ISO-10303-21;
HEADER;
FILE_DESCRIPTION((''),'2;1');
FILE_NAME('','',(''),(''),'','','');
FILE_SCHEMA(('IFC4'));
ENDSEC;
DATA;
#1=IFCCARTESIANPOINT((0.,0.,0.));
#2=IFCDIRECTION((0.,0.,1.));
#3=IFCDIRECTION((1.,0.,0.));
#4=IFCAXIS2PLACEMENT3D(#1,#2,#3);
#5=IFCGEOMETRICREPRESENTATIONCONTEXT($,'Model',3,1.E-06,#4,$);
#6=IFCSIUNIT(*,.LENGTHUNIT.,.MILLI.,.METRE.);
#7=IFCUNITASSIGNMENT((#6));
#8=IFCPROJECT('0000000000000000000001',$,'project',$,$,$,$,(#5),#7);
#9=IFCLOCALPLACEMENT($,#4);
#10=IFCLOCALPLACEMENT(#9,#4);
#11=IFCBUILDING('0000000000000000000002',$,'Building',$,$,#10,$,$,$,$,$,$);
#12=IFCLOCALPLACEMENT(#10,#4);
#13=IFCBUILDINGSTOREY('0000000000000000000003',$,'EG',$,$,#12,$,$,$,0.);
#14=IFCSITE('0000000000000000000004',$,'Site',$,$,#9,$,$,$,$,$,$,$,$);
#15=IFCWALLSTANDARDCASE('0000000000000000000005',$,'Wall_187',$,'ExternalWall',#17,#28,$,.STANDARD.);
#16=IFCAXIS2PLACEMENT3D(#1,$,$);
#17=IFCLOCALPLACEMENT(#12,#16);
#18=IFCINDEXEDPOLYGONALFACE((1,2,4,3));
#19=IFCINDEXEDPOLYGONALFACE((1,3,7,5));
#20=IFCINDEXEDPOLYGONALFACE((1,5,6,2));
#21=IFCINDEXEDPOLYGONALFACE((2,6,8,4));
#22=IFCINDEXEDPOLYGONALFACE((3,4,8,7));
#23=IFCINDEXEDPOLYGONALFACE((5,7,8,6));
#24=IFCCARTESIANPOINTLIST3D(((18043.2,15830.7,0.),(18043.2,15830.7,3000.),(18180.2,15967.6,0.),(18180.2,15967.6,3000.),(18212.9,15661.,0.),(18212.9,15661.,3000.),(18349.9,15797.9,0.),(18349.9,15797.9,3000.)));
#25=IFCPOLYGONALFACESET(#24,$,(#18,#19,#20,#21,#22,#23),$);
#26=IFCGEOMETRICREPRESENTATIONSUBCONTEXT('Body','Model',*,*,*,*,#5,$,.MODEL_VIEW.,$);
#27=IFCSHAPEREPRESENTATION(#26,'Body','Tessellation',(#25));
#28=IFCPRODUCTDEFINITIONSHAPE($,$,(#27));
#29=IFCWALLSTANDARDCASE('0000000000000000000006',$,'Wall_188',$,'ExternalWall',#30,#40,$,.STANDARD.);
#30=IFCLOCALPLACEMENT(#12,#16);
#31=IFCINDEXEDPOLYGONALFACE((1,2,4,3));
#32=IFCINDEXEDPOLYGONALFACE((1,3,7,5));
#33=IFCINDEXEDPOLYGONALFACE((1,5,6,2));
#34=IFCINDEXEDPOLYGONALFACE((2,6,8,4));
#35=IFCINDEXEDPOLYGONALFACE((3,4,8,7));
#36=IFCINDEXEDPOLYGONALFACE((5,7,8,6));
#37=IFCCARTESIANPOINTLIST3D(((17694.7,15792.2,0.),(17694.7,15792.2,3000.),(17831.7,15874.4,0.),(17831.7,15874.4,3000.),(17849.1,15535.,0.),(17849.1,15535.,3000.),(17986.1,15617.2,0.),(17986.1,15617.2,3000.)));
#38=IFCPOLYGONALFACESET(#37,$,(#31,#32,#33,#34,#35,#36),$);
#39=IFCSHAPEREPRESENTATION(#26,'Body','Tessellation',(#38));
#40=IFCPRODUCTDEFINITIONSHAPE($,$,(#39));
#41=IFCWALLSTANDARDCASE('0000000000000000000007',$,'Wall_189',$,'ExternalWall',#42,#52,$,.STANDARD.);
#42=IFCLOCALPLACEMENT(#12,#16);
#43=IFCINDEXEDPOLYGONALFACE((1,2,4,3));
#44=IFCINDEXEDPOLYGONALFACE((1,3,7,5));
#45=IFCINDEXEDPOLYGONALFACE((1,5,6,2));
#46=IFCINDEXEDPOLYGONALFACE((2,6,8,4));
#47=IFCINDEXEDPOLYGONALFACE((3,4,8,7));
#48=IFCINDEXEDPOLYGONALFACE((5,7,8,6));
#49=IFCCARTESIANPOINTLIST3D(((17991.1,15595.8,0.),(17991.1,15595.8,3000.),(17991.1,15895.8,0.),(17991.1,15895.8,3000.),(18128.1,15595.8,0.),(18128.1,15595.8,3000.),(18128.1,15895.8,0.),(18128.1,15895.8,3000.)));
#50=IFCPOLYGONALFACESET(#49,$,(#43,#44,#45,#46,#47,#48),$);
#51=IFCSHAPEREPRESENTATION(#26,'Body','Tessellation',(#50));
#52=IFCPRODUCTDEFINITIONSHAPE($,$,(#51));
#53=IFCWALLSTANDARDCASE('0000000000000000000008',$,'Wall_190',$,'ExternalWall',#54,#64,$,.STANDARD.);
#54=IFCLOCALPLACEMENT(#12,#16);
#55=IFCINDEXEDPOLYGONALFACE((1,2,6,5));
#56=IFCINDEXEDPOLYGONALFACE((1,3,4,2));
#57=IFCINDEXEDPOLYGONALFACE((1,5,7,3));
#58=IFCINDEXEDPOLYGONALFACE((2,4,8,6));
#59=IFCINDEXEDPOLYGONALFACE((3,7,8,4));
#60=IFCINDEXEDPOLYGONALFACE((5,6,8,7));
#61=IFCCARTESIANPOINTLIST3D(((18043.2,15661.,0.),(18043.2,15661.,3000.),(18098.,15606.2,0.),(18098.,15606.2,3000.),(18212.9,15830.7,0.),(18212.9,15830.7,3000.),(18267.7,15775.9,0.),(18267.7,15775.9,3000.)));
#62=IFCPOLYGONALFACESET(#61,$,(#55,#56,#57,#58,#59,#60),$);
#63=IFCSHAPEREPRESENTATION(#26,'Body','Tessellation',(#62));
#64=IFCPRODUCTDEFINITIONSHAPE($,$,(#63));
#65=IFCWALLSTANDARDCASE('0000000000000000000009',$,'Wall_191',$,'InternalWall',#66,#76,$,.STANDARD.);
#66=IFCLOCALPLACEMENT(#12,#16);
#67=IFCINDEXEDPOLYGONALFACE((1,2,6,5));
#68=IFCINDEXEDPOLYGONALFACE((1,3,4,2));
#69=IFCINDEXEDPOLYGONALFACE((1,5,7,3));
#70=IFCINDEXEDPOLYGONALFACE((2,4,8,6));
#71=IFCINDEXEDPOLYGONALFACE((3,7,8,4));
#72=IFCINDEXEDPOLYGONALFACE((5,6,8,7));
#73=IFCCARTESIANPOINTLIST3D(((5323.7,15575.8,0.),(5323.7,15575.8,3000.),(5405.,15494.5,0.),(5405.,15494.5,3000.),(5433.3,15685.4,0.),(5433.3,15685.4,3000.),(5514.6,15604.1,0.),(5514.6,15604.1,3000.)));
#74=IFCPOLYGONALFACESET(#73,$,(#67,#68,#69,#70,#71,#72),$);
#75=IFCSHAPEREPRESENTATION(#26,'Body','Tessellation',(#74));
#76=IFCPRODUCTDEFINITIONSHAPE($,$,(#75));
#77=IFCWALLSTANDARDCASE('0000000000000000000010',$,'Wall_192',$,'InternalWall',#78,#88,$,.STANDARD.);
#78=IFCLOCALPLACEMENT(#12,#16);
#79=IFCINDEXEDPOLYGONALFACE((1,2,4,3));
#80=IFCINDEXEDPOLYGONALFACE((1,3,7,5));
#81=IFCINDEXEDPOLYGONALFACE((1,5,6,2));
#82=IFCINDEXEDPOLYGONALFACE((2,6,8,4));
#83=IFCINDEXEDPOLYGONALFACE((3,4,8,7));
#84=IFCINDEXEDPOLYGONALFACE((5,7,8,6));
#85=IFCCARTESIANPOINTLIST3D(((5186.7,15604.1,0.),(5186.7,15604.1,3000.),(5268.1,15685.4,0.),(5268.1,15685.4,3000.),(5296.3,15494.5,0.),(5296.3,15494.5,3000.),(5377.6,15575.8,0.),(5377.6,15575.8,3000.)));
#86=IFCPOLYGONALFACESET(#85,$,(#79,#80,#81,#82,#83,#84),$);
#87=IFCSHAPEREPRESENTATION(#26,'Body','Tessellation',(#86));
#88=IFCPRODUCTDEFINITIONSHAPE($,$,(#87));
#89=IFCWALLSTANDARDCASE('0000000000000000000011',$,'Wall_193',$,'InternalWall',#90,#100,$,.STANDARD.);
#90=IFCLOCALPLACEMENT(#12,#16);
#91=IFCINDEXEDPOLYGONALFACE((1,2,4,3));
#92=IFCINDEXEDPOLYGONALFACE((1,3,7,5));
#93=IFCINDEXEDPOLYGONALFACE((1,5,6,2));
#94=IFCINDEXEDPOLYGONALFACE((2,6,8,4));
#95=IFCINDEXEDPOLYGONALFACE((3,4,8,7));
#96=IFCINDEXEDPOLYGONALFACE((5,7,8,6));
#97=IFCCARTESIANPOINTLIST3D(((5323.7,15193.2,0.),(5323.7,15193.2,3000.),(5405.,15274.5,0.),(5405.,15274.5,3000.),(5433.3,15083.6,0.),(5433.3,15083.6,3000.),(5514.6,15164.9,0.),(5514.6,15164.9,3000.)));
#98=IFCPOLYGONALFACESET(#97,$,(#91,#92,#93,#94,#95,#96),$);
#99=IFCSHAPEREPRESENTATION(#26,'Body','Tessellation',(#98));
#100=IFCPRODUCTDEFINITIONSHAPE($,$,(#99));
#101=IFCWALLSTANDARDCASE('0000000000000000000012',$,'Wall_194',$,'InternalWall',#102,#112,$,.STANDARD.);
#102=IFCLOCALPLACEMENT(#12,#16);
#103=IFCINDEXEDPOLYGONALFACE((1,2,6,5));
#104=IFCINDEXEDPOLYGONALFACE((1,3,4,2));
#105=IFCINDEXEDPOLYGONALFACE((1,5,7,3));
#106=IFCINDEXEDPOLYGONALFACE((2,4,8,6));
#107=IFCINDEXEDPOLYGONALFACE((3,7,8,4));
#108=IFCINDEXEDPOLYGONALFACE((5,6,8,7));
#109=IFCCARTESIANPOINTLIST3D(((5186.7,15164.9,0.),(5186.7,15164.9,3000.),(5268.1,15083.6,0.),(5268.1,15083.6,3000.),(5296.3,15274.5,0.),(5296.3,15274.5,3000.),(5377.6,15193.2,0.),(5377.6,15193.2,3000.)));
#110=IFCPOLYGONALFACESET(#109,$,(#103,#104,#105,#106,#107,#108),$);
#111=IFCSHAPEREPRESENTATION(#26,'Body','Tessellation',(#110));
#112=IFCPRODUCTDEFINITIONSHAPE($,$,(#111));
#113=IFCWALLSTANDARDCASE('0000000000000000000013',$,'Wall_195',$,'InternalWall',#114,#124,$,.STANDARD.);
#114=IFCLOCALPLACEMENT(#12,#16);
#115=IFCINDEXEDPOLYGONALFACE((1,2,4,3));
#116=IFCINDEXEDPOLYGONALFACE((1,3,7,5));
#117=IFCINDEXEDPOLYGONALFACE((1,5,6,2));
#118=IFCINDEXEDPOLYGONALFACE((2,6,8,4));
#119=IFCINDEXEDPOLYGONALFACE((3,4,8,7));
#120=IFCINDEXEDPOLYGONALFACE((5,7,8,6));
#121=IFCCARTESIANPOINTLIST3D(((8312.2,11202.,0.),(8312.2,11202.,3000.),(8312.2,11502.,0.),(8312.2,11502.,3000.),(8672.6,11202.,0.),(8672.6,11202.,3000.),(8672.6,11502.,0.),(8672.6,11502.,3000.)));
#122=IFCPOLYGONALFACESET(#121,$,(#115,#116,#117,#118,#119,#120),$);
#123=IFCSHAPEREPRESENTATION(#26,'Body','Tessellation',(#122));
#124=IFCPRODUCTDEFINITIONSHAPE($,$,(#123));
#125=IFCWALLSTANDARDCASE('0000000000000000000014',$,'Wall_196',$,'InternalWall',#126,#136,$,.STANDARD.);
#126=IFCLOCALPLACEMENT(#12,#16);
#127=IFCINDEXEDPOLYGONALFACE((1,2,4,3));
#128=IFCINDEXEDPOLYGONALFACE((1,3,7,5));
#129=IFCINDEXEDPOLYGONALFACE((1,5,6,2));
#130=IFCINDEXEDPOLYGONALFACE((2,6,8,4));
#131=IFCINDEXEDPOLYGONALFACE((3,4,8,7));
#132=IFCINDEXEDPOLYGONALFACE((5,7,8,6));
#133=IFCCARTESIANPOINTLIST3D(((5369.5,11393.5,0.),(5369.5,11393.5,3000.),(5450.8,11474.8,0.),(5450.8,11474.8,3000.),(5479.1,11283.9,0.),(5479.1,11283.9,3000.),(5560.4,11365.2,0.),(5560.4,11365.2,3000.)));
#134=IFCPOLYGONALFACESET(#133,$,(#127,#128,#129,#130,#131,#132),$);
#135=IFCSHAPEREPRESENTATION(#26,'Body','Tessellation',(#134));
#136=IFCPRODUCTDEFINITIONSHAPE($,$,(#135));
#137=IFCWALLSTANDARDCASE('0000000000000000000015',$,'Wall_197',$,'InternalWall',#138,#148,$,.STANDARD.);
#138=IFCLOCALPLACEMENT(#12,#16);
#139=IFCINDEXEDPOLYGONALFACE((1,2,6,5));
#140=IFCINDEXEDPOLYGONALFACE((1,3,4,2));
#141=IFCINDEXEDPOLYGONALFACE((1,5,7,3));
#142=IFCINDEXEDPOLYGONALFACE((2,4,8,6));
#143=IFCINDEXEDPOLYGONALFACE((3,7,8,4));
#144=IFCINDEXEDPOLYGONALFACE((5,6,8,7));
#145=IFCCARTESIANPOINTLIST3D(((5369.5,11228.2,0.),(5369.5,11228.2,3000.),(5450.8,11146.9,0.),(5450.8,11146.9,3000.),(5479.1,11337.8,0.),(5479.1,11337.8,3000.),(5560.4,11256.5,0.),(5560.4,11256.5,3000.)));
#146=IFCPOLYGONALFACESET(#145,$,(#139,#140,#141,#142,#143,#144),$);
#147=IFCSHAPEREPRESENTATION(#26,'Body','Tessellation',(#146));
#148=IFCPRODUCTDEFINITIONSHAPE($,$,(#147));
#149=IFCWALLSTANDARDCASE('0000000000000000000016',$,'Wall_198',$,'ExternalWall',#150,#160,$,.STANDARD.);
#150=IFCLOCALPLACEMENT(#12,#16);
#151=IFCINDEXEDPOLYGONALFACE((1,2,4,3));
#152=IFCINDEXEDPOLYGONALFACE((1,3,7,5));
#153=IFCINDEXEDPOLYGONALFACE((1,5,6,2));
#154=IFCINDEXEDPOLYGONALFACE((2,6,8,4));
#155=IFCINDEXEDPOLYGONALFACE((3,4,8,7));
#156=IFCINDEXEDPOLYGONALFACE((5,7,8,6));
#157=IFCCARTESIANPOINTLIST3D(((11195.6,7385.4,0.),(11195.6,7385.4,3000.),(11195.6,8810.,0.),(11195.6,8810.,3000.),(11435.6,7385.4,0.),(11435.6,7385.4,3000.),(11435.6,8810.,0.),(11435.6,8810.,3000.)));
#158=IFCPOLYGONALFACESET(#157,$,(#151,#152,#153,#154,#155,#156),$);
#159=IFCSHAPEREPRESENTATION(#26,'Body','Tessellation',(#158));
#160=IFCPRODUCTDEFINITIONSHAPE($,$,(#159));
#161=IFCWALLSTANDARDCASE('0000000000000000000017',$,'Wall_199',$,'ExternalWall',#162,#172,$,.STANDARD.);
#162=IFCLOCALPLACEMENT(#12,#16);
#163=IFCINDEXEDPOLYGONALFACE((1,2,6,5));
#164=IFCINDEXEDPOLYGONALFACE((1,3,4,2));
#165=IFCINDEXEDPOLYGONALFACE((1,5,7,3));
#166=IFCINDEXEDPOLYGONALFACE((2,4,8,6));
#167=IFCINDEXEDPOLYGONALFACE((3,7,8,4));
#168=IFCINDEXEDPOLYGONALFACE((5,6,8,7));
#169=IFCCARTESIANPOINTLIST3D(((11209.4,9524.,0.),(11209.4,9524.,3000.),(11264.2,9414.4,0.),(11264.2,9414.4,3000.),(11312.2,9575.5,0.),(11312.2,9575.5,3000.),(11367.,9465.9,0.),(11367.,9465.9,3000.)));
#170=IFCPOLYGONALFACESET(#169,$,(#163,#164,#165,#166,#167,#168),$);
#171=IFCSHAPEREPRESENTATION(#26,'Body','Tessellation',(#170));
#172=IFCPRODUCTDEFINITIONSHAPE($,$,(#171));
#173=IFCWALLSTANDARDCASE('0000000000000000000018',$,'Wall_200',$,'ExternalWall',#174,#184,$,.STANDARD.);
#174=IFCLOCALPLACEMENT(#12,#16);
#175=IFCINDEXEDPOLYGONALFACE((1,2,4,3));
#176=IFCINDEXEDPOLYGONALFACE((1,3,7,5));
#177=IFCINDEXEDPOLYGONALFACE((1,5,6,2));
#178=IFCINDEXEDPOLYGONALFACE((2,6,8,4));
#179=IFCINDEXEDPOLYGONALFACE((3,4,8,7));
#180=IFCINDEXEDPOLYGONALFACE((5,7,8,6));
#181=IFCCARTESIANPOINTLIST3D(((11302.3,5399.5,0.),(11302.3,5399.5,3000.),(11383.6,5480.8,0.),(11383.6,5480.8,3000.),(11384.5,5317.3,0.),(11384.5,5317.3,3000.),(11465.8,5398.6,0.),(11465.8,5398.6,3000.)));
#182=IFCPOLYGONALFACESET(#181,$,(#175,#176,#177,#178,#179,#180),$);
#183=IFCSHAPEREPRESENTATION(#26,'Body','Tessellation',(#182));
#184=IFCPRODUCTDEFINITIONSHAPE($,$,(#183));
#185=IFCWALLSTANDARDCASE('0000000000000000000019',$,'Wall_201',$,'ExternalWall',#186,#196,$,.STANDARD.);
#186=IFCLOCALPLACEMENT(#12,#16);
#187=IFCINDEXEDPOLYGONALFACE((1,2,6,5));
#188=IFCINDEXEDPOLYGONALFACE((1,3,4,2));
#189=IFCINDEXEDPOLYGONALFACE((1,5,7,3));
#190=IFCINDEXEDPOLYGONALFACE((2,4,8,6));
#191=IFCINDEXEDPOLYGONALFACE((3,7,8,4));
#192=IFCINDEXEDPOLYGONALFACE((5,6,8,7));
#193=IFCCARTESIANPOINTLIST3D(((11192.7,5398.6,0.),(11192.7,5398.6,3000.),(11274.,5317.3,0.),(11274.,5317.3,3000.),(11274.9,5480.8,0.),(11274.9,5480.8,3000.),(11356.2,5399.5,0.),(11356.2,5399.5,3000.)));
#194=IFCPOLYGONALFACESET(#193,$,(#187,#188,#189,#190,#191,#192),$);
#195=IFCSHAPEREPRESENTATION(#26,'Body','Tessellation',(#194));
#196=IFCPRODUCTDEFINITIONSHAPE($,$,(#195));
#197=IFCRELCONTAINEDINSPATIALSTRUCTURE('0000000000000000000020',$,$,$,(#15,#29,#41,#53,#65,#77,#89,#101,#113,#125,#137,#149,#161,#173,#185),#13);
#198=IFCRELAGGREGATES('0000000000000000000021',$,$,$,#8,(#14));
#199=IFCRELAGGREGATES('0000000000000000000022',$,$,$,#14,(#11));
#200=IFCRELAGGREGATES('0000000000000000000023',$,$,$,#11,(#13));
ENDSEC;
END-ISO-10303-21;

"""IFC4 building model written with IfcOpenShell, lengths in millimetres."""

from ifc_helpers import new_model, si_unit, frame, origin_with_axes, place, context, subcontext, project, spatial, rectangle, extrude, element, save


model = new_model("IFC4")

# Units and contexts
model_context = context("Model", 3, precision=1e-06, world=origin_with_axes())
body_context = subcontext(model_context, "Body", "Model", "MODEL_VIEW")
ifc_project = project(units=[si_unit("LENGTHUNIT", "METRE", prefix="MILLI")], contexts=[model_context])

# Site, building, storey
site_placement = place(None, origin_with_axes())
site = spatial("IfcSite", under=ifc_project, at=site_placement, Name="Site")
building_placement = place(site_placement, origin_with_axes())
building = spatial("IfcBuilding", under=site, at=building_placement, Name="Building")
storey_placement = place(building_placement, origin_with_axes())
storey = spatial("IfcBuildingStorey", under=building, at=storey_placement, Name="EG", Elevation=0.0)

# Walls
wall_1_placement = place(storey_placement, origin_with_axes())
element("IfcWallStandardCase", 1, at=wall_1_placement, inside=storey, Name="Wall_187", ObjectType="ExternalWall", PredefinedType="STANDARD", context=body_context, shape_type="SweptSolid", body=[
    extrude(rectangle(XDim=193.7, YDim=240.0), frame((18196.6, 15814.3, 0.0), z_axis=(0.0, 0.0, 1.0), x_axis=(0.707107, 0.707107, 0.0)), (0.0, 0.0, 1.0), 3000.0),
])
wall_2_placement = place(storey_placement, origin_with_axes())
element("IfcWallStandardCase", 2, at=wall_2_placement, inside=storey, Name="Wall_188", ObjectType="ExternalWall", PredefinedType="STANDARD", context=body_context, shape_type="SweptSolid", body=[
    extrude(rectangle(XDim=159.8, YDim=300.0), frame((17840.4, 15704.7, 0.0), z_axis=(0.0, 0.0, 1.0), x_axis=(0.857493, 0.514496, 0.0)), (0.0, 0.0, 1.0), 3000.0),
])
wall_3_placement = place(storey_placement, origin_with_axes())
element("IfcWallStandardCase", 3, at=wall_3_placement, inside=storey, Name="Wall_189", ObjectType="ExternalWall", PredefinedType="STANDARD", context=body_context, shape_type="SweptSolid", body=[
    extrude(rectangle(XDim=137.0, YDim=300.0), frame((18059.6, 15745.8, 0.0), z_axis=(0.0, 0.0, 1.0), x_axis=(1.0, 0.0, 0.0)), (0.0, 0.0, 1.0), 3000.0),
])
wall_4_placement = place(storey_placement, origin_with_axes())
element("IfcWallStandardCase", 4, at=wall_4_placement, inside=storey, Name="Wall_190", ObjectType="ExternalWall", PredefinedType="STANDARD", context=body_context, shape_type="SweptSolid", body=[
    extrude(rectangle(XDim=77.5, YDim=240.0), frame((18155.5, 15718.4, 0.0), z_axis=(0.0, 0.0, 1.0), x_axis=(0.707107, -0.707107, 0.0)), (0.0, 0.0, 1.0), 3000.0),
])
wall_5_placement = place(storey_placement, origin_with_axes())
element("IfcWallStandardCase", 5, at=wall_5_placement, inside=storey, Name="Wall_191", ObjectType="InternalWall", PredefinedType="STANDARD", context=body_context, shape_type="SweptSolid", body=[
    extrude(rectangle(XDim=155.0, YDim=115.0), frame((5419.2, 15590.0, 0.0), z_axis=(0.0, 0.0, 1.0), x_axis=(0.707107, 0.707107, 0.0)), (0.0, 0.0, 1.0), 3000.0),
])
wall_6_placement = place(storey_placement, origin_with_axes())
element("IfcWallStandardCase", 6, at=wall_6_placement, inside=storey, Name="Wall_192", ObjectType="InternalWall", PredefinedType="STANDARD", context=body_context, shape_type="SweptSolid", body=[
    extrude(rectangle(XDim=155.0, YDim=115.0), frame((5282.2, 15590.0, 0.0), z_axis=(0.0, 0.0, 1.0), x_axis=(-0.707107, 0.707107, 0.0)), (0.0, 0.0, 1.0), 3000.0),
])
wall_7_placement = place(storey_placement, origin_with_axes())
element("IfcWallStandardCase", 7, at=wall_7_placement, inside=storey, Name="Wall_193", ObjectType="InternalWall", PredefinedType="STANDARD", context=body_context, shape_type="SweptSolid", body=[
    extrude(rectangle(XDim=155.0, YDim=115.0), frame((5419.2, 15179.0, 0.0), z_axis=(0.0, 0.0, 1.0), x_axis=(0.707107, -0.707107, 0.0)), (0.0, 0.0, 1.0), 3000.0),
])
wall_8_placement = place(storey_placement, origin_with_axes())
element("IfcWallStandardCase", 8, at=wall_8_placement, inside=storey, Name="Wall_194", ObjectType="InternalWall", PredefinedType="STANDARD", context=body_context, shape_type="SweptSolid", body=[
    extrude(rectangle(XDim=155.0, YDim=115.0), frame((5282.2, 15179.0, 0.0), z_axis=(0.0, 0.0, 1.0), x_axis=(-0.707107, -0.707107, 0.0)), (0.0, 0.0, 1.0), 3000.0),
])
wall_9_placement = place(storey_placement, origin_with_axes())
element("IfcWallStandardCase", 9, at=wall_9_placement, inside=storey, Name="Wall_195", ObjectType="InternalWall", PredefinedType="STANDARD", context=body_context, shape_type="SweptSolid", body=[
    extrude(rectangle(XDim=360.4, YDim=300.0), frame((8492.4, 11352.0, 0.0), z_axis=(0.0, 0.0, 1.0), x_axis=(1.0, 0.0, 0.0)), (0.0, 0.0, 1.0), 3000.0),
])
wall_10_placement = place(storey_placement, origin_with_axes())
element("IfcWallStandardCase", 10, at=wall_10_placement, inside=storey, Name="Wall_196", ObjectType="InternalWall", PredefinedType="STANDARD", context=body_context, shape_type="SweptSolid", body=[
    extrude(rectangle(XDim=155.0, YDim=115.0), frame((5465.0, 11379.4, 0.0), z_axis=(0.0, 0.0, 1.0), x_axis=(-0.707107, 0.707107, 0.0)), (0.0, 0.0, 1.0), 3000.0),
])
wall_11_placement = place(storey_placement, origin_with_axes())
element("IfcWallStandardCase", 11, at=wall_11_placement, inside=storey, Name="Wall_197", ObjectType="InternalWall", PredefinedType="STANDARD", context=body_context, shape_type="SweptSolid", body=[
    extrude(rectangle(XDim=155.0, YDim=115.0), frame((5465.0, 11242.4, 0.0), z_axis=(0.0, 0.0, 1.0), x_axis=(-0.707107, -0.707107, 0.0)), (0.0, 0.0, 1.0), 3000.0),
])
wall_12_placement = place(storey_placement, origin_with_axes())
element("IfcWallStandardCase", 12, at=wall_12_placement, inside=storey, Name="Wall_198", ObjectType="ExternalWall", PredefinedType="STANDARD", context=body_context, shape_type="SweptSolid", body=[
    extrude(rectangle(XDim=1424.7, YDim=240.0), frame((11315.6, 8097.7, 0.0), z_axis=(0.0, 0.0, 1.0), x_axis=(0.0, 1.0, 0.0)), (0.0, 0.0, 1.0), 3000.0),
])
wall_13_placement = place(storey_placement, origin_with_axes())
element("IfcWallStandardCase", 13, at=wall_13_placement, inside=storey, Name="Wall_199", ObjectType="ExternalWall", PredefinedType="STANDARD", context=body_context, shape_type="SweptSolid", body=[
    extrude(rectangle(XDim=122.5, YDim=115.0), frame((11288.2, 9494.9, 0.0), z_axis=(0.0, 0.0, 1.0), x_axis=(-0.447214, 0.894427, 0.0)), (0.0, 0.0, 1.0), 3000.0),
])
wall_14_placement = place(storey_placement, origin_with_axes())
element("IfcWallStandardCase", 14, at=wall_14_placement, inside=storey, Name="Wall_200", ObjectType="ExternalWall", PredefinedType="STANDARD", context=body_context, shape_type="SweptSolid", body=[
    extrude(rectangle(XDim=116.2, YDim=115.0), frame((11384.1, 5399.1, 0.0), z_axis=(0.0, 0.0, 1.0), x_axis=(0.707107, -0.707107, 0.0)), (0.0, 0.0, 1.0), 3000.0),
])
wall_15_placement = place(storey_placement, origin_with_axes())
element("IfcWallStandardCase", 15, at=wall_15_placement, inside=storey, Name="Wall_201", ObjectType="ExternalWall", PredefinedType="STANDARD", context=body_context, shape_type="SweptSolid", body=[
    extrude(rectangle(XDim=116.2, YDim=115.0), frame((11274.5, 5399.1, 0.0), z_axis=(0.0, 0.0, 1.0), x_axis=(-0.707107, -0.707107, 0.0)), (0.0, 0.0, 1.0), 3000.0),
])

save(model, "model.ifc")
